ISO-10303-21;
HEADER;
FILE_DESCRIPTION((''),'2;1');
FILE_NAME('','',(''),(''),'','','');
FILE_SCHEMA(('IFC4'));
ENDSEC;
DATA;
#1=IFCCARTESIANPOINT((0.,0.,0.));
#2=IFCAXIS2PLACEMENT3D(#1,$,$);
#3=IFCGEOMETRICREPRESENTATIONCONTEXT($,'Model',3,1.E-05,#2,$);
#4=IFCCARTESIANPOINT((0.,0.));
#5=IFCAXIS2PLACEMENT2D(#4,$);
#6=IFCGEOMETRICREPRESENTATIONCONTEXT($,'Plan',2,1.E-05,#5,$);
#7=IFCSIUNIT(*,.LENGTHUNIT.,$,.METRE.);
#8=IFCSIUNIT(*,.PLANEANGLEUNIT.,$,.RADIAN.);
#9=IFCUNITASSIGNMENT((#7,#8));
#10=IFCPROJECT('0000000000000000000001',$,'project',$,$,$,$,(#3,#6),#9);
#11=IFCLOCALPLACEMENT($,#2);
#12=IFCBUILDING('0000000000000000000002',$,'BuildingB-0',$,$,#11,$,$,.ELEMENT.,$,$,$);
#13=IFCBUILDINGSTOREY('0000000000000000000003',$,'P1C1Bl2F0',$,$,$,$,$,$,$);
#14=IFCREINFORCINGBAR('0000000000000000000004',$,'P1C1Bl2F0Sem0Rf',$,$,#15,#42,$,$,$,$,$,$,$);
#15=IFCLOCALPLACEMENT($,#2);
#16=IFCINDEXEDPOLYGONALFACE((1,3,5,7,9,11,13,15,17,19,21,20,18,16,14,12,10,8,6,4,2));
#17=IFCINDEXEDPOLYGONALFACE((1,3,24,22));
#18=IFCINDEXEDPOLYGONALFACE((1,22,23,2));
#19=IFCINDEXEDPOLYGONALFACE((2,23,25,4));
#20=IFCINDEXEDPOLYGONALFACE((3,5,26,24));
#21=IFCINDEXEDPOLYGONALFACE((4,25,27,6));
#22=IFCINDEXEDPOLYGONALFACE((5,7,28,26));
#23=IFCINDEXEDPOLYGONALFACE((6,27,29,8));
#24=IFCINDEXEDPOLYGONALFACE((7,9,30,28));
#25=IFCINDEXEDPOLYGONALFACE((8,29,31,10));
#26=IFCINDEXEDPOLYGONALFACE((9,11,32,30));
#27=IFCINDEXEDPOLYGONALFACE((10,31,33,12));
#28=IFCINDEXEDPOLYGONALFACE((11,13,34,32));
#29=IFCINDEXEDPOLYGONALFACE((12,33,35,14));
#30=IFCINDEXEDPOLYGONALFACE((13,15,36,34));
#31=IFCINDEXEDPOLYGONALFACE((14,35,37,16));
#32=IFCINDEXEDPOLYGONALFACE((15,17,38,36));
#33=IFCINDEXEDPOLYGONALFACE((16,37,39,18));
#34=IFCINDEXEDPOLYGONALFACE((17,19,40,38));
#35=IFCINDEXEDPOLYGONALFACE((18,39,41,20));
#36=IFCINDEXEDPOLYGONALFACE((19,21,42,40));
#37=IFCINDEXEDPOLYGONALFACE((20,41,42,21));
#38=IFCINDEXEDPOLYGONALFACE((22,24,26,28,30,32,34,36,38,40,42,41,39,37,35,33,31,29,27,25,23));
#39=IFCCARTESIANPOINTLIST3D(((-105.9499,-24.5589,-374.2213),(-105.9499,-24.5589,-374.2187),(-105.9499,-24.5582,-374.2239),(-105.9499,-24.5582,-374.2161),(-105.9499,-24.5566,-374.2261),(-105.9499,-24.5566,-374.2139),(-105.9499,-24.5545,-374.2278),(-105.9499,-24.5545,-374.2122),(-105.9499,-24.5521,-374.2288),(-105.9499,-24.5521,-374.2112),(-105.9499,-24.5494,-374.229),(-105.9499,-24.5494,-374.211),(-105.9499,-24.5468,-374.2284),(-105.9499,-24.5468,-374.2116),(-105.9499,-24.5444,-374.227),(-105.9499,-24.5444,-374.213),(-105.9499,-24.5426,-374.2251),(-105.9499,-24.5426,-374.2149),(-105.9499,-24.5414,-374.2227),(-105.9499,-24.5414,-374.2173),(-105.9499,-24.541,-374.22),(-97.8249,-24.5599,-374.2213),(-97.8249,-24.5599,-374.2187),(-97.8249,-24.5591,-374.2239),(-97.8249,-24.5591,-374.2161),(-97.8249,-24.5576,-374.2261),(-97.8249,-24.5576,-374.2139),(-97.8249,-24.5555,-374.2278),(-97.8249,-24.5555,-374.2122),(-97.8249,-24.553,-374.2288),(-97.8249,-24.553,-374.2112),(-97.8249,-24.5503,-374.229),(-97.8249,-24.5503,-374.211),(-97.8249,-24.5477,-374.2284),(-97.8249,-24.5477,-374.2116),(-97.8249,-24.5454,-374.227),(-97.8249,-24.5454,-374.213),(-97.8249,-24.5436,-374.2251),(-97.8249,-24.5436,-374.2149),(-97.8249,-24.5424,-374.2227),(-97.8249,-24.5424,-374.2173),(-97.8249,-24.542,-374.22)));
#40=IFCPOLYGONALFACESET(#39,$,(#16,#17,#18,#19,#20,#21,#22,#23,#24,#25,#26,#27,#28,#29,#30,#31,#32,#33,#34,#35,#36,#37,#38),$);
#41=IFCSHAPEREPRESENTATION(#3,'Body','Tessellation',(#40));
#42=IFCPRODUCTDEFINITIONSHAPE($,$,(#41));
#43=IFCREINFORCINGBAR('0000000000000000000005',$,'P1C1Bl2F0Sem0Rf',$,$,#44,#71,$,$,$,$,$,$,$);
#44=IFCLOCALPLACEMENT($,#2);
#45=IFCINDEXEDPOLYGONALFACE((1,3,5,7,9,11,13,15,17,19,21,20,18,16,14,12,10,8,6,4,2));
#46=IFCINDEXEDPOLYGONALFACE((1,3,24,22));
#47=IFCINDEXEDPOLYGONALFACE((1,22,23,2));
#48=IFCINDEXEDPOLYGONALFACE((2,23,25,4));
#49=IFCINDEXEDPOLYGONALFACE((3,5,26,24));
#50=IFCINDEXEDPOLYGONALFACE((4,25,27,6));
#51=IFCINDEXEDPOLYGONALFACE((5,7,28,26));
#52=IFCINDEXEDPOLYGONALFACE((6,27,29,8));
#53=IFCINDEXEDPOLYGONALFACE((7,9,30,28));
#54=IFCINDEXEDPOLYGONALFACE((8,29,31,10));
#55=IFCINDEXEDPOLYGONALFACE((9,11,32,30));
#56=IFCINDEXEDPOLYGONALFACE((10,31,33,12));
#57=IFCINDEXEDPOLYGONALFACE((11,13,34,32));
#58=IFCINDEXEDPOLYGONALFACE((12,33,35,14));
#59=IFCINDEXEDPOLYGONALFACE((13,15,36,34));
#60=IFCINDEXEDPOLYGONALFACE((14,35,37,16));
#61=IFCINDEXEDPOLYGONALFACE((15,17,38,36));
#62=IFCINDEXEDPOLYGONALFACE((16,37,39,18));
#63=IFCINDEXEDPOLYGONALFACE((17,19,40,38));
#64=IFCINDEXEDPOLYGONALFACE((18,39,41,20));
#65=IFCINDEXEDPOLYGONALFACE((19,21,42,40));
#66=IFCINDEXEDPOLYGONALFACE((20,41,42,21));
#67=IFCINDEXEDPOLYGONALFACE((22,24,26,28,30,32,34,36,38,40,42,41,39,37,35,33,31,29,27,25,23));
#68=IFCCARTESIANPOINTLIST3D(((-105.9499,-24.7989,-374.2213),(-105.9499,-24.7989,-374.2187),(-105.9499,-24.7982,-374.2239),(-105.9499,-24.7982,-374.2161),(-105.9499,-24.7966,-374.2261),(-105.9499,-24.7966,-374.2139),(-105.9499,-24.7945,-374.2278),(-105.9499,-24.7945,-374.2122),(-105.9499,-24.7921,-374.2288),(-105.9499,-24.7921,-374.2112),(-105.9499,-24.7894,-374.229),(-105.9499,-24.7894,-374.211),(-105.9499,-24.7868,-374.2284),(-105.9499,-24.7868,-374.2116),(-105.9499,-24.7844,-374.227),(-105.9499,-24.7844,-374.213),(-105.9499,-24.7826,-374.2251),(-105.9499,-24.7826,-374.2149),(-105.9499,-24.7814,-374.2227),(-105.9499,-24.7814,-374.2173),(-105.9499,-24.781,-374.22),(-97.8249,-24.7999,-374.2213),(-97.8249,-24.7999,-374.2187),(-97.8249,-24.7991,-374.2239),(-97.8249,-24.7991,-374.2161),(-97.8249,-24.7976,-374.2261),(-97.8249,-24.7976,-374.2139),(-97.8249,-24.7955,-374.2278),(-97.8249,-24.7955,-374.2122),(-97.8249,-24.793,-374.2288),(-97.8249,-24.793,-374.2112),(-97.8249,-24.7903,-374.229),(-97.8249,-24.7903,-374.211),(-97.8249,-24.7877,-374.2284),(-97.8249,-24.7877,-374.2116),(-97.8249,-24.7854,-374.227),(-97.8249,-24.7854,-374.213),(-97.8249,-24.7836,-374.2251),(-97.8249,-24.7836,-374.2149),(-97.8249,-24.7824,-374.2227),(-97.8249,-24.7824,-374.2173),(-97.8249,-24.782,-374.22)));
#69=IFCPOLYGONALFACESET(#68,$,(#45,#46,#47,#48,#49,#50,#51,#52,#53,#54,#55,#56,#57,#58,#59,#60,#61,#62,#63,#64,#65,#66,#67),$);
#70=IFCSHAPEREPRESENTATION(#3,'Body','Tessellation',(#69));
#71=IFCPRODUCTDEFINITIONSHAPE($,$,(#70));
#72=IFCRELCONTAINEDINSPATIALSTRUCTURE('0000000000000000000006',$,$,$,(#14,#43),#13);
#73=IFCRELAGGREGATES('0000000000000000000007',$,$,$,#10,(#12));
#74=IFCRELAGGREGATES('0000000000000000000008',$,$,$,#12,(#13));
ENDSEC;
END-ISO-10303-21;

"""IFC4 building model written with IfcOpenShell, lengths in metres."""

from ifc_helpers import new_model, entity, si_unit, origin, origin_2d, place, context, project, spatial, element, save


model = new_model("IFC4")

# Units and contexts
model_context = context("Model", 3, precision=1e-05, world=origin())
plan_context = context("Plan", 2, precision=1e-05, world=origin_2d())
ifc_project = project(units=[si_unit("LENGTHUNIT", "METRE"), si_unit("PLANEANGLEUNIT", "RADIAN")], contexts=[model_context, plan_context])

# Building, storey
building_placement = place(None, origin())
building = spatial("IfcBuilding", under=ifc_project, at=building_placement, Name="BuildingB-0", CompositionType="ELEMENT")
storey = spatial("IfcBuildingStorey", under=building, Name="P1C1Bl2F0")

# Reinforcing bars
element("IfcReinforcingBar", 1, inside=storey, Name="P1C1Bl2F0Sem0Rf", context=model_context, shape_type="SweptSolid", body=[
    entity("IfcSurfaceCurveSweptAreaSolid", entity("IfcCircleProfileDef", "AREA", None, None, 0.009), None, entity("IfcPolyline", [entity("IfcCartesianPoint", [97.8249, 24.551, 374.22]), entity("IfcCartesianPoint", [105.9499, 24.55, 374.22])]), None, None, entity("IfcPlane", entity("IfcAxis2Placement3D", entity("IfcCartesianPoint", [97.8249, 24.551, 374.22]), entity("IfcDirection", [0.0, 0.0, 1.0]), entity("IfcDirection", [1.0, 0.0, 0.0])))),
])
element("IfcReinforcingBar", 2, inside=storey, Name="P1C1Bl2F0Sem0Rf", context=model_context, shape_type="SweptSolid", body=[
    entity("IfcSurfaceCurveSweptAreaSolid", entity("IfcCircleProfileDef", "AREA", None, None, 0.009), None, entity("IfcPolyline", [entity("IfcCartesianPoint", [97.8249, 24.791, 374.22]), entity("IfcCartesianPoint", [105.9499, 24.79, 374.22])]), None, None, entity("IfcPlane", entity("IfcAxis2Placement3D", entity("IfcCartesianPoint", [97.8249, 24.791, 374.22]), entity("IfcDirection", [0.0, 0.0, 1.0]), entity("IfcDirection", [1.0, 0.0, 0.0])))),
])

save(model, "model.ifc")
